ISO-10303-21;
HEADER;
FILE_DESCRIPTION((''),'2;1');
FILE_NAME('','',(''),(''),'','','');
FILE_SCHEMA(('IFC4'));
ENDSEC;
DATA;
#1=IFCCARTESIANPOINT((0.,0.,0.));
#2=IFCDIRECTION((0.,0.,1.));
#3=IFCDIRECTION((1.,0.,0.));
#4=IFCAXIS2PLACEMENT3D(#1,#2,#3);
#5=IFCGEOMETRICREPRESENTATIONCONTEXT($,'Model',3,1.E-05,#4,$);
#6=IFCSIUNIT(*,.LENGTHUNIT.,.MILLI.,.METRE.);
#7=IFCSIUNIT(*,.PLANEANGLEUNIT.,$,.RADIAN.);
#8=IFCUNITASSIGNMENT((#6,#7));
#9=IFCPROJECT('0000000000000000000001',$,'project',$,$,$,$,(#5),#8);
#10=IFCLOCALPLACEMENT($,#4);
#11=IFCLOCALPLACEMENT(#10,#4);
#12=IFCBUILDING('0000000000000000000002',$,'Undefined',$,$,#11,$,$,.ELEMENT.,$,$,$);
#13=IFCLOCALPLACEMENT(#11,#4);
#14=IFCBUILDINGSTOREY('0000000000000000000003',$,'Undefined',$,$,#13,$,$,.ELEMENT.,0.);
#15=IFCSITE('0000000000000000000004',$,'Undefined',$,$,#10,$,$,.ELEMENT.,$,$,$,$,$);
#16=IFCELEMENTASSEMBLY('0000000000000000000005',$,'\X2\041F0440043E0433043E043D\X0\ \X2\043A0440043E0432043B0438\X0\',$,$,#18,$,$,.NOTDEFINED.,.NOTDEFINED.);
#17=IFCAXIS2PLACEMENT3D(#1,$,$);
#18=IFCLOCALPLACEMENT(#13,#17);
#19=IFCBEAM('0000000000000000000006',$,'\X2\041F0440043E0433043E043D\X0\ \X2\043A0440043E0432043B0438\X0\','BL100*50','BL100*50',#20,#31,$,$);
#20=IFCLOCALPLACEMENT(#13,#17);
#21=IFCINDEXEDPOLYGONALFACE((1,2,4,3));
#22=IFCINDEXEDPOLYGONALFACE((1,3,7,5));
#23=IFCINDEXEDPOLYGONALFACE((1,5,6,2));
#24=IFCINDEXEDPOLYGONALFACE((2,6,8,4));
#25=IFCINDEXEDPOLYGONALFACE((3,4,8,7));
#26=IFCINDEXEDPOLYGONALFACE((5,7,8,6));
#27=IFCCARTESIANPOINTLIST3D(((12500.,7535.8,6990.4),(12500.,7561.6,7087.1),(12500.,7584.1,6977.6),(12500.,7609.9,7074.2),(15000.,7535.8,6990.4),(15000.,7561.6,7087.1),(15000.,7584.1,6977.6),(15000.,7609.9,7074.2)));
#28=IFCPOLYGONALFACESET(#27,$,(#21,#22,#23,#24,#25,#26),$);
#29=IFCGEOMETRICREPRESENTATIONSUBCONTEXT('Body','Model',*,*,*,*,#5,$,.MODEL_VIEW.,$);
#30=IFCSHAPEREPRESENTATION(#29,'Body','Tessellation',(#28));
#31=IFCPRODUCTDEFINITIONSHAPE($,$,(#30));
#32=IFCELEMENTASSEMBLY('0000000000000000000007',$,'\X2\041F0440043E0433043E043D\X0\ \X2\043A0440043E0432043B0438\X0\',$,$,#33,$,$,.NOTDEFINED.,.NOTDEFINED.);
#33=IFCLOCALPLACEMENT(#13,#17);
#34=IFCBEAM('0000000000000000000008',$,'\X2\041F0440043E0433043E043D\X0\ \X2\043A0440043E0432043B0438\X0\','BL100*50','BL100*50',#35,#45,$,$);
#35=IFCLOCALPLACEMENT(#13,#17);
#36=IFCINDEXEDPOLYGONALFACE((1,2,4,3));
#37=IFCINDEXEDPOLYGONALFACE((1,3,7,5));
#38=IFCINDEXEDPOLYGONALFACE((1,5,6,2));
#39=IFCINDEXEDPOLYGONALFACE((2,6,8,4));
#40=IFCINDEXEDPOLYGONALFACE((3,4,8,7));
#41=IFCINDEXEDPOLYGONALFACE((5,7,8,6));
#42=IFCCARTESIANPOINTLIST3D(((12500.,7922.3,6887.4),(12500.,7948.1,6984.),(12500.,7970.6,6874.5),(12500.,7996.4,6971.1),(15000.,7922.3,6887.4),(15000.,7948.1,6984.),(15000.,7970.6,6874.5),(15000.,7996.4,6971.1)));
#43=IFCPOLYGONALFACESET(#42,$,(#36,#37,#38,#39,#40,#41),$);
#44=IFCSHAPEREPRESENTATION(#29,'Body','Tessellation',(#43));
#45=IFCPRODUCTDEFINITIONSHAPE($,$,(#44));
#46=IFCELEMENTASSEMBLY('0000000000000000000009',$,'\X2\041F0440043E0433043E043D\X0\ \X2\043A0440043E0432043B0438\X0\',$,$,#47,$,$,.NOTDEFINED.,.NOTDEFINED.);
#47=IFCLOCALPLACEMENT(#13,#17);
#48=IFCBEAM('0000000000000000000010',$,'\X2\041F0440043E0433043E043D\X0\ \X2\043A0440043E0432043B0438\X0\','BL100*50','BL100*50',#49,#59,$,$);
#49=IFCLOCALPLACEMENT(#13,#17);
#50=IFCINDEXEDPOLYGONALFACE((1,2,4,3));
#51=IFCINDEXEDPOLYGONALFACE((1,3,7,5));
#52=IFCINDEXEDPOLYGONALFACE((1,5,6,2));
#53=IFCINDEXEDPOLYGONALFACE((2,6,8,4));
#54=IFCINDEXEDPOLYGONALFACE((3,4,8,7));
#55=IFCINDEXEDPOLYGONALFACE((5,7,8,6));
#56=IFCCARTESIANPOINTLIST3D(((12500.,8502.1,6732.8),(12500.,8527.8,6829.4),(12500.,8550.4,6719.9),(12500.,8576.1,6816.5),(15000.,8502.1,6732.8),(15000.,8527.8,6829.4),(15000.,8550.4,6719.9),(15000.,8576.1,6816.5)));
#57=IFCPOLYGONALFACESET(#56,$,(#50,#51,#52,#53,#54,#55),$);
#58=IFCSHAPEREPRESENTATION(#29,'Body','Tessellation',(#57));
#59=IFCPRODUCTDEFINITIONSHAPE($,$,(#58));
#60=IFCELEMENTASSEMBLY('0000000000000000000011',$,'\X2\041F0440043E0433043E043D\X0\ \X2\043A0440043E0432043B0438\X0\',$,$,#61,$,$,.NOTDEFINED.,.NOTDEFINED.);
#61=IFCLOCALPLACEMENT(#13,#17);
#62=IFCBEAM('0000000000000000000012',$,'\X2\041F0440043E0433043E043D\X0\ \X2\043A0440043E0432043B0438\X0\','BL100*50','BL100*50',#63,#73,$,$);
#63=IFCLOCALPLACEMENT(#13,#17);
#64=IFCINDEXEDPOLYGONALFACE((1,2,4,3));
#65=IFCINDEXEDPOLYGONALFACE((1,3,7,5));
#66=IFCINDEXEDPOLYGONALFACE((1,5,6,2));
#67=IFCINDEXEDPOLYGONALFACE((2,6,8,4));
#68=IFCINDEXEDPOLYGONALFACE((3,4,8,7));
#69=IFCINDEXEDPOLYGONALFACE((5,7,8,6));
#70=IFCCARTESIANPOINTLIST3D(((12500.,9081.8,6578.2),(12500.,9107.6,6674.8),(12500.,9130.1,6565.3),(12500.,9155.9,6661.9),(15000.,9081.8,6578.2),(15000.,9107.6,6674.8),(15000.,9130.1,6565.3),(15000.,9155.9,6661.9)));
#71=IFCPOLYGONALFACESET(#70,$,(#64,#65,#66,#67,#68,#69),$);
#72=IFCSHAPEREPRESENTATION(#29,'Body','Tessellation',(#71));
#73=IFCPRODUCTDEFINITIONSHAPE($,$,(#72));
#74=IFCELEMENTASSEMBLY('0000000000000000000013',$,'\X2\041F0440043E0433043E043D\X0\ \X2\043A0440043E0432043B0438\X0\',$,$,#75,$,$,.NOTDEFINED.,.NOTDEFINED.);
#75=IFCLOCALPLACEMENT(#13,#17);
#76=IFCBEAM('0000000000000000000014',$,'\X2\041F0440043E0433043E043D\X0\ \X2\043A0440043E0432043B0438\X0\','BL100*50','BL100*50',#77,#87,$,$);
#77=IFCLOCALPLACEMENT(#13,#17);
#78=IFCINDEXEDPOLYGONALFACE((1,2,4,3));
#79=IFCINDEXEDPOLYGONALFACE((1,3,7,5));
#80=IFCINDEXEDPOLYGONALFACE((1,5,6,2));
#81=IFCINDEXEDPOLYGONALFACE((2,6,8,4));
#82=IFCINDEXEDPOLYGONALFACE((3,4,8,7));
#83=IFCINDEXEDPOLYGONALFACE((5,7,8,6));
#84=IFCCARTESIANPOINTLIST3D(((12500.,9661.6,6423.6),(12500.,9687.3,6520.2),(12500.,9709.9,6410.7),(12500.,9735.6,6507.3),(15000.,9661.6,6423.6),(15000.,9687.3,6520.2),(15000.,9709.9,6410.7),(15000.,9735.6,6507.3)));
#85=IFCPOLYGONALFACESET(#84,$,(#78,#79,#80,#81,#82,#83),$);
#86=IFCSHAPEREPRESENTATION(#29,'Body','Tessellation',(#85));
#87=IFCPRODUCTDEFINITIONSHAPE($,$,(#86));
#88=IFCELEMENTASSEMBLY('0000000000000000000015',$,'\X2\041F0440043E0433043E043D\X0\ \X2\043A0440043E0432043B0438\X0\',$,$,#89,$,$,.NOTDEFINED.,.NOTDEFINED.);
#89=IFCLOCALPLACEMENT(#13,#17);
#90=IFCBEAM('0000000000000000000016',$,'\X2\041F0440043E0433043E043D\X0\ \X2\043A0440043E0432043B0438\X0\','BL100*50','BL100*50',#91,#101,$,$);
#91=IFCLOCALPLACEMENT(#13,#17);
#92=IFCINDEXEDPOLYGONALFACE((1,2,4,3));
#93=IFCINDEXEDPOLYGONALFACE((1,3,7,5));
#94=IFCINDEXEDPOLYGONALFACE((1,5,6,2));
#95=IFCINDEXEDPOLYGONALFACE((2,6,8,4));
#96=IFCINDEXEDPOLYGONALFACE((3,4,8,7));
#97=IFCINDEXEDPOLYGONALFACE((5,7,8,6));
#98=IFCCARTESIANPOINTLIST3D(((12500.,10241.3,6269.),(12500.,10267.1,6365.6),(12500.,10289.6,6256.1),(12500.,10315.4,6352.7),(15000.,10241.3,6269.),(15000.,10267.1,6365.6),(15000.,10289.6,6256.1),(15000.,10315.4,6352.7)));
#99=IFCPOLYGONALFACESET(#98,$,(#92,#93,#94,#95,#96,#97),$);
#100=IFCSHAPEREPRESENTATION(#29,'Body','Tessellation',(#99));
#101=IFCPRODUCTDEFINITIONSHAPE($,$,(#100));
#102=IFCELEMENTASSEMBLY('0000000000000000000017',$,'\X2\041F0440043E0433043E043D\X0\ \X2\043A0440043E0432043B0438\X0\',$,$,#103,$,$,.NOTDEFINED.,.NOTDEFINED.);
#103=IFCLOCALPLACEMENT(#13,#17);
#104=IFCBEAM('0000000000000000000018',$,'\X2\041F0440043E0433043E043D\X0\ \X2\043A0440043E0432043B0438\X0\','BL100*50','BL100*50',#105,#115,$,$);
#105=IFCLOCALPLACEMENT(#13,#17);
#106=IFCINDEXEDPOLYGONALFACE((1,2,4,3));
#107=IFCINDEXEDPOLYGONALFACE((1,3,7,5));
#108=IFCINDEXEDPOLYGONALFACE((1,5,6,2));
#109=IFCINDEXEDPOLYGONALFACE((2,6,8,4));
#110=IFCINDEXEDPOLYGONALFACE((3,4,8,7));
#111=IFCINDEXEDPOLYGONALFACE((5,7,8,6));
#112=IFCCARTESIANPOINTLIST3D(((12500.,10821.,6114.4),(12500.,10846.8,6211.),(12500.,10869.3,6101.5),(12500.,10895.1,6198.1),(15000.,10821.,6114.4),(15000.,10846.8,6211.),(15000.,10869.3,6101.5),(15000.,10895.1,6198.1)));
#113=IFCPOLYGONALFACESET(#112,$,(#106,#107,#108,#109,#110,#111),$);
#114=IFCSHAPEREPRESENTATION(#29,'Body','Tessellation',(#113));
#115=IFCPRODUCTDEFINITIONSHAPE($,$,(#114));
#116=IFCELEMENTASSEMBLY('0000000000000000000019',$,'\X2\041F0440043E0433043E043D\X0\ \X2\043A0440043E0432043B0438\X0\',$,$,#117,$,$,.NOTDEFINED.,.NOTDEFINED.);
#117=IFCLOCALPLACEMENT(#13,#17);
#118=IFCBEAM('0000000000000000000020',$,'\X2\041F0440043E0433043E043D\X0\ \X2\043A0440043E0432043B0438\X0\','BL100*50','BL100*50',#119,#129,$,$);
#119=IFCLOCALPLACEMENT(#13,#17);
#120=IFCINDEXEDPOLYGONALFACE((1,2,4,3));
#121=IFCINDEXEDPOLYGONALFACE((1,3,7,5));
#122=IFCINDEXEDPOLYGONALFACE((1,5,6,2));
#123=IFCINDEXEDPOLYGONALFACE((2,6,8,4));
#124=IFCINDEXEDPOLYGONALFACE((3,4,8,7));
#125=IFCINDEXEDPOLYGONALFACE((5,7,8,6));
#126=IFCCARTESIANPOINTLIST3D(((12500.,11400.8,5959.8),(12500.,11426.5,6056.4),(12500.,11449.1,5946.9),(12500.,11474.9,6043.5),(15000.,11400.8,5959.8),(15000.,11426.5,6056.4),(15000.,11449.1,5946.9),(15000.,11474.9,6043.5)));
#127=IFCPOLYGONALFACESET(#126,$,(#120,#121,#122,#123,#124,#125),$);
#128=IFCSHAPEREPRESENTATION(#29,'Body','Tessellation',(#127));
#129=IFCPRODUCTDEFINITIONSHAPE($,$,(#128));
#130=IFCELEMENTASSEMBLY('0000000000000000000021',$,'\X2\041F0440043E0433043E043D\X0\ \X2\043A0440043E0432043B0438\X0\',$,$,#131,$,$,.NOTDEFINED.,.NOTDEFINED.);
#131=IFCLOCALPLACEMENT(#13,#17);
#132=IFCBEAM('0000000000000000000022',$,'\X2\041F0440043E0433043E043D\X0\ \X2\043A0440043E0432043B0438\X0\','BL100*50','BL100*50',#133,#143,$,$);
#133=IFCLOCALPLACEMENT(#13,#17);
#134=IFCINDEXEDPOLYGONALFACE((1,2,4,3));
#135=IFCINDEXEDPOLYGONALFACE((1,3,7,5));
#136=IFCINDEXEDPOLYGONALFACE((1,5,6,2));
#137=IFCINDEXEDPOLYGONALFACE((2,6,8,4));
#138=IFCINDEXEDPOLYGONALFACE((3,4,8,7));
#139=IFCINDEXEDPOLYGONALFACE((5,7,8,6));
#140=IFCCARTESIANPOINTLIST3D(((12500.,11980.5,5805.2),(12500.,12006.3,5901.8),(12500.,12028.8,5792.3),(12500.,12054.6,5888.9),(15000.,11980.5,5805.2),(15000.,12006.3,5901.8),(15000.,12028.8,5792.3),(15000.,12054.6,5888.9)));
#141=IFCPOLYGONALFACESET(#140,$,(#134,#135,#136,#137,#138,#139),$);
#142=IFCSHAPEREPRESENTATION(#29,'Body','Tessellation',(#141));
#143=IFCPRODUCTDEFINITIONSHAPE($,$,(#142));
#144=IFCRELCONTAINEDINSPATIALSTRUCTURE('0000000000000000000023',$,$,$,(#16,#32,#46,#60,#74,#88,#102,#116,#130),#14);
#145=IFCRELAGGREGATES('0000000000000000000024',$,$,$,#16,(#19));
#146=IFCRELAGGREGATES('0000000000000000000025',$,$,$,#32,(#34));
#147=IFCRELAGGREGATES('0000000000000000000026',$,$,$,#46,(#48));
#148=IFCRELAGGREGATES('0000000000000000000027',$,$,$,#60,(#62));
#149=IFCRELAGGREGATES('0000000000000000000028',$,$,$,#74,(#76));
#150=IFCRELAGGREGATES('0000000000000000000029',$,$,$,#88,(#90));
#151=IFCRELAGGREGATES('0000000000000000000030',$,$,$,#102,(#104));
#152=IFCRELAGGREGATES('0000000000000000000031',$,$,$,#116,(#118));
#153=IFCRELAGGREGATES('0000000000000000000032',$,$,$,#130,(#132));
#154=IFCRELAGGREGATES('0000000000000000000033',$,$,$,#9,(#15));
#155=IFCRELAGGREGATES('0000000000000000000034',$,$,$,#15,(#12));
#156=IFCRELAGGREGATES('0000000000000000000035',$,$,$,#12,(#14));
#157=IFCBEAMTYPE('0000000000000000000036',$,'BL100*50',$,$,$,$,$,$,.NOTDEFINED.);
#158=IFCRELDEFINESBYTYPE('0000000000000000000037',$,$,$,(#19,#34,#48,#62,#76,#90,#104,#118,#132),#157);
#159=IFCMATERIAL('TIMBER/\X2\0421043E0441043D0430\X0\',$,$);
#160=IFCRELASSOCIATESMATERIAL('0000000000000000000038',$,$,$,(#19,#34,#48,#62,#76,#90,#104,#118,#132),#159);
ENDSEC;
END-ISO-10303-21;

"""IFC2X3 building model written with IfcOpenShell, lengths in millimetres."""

from ifc_helpers import new_model, si_unit, frame, origin_with_axes, origin_2d_with_axis, place, context, subcontext, project, spatial, rectangle, extrude, material, type_object, element, aggregate, save


model = new_model("IFC2X3")

# Units and contexts
model_context = context("Model", 3, precision=1e-05, world=origin_with_axes())
body_context = subcontext(model_context, "Body", "Model", "MODEL_VIEW")
ifc_project = project(units=[si_unit("LENGTHUNIT", "METRE", prefix="MILLI"), si_unit("PLANEANGLEUNIT", "RADIAN")], contexts=[model_context])

# Site, building, storey
site_placement = place(None, origin_with_axes())
site = spatial("IfcSite", under=ifc_project, at=site_placement, Name="Undefined", CompositionType="ELEMENT")
building_placement = place(site_placement, origin_with_axes())
building = spatial("IfcBuilding", under=site, at=building_placement, Name="Undefined", CompositionType="ELEMENT")
storey_placement = place(building_placement, origin_with_axes())
storey = spatial("IfcBuildingStorey", under=building, at=storey_placement, Name="Undefined", CompositionType="ELEMENT", Elevation=0.0)

# Element assemblies, beams
assembly_1_placement = place(storey_placement, origin_with_axes())
assembly_1 = element("IfcElementAssembly", 1, at=assembly_1_placement, inside=storey, Name="Прогон кровли", AssemblyPlace="NOTDEFINED", PredefinedType="NOTDEFINED")
ifc_material_1 = material(Name="TIMBER/Сосна")
beam_type_1 = type_object("IfcBeamType", Name="BL100*50", PredefinedType="NOTDEFINED")
beam_1_placement = place(assembly_1_placement, frame((12500.0, 7572.9, 7032.3), z_axis=(0.0, -0.257663, -0.966235), x_axis=(1.0, 0.0, 0.0)))
beam_1 = element("IfcBeam", 2, at=beam_1_placement, type_object=beam_type_1, material=ifc_material_1, Name="Прогон кровли", Description="BL100*50", ObjectType="BL100*50", context=body_context, shape_type="SweptSolid", body=[
    extrude(rectangle(XDim=50.0, YDim=100.0, at=origin_2d_with_axis()), frame((2500.0, 0.0, 0.0), z_axis=(-1.0, 0.0, 0.0), x_axis=(0.0, -1.0, 0.0)), (0.0, 0.0, 1.0), 2500.0),
])
aggregate(assembly_1, [beam_1])
assembly_2_placement = place(storey_placement, origin_with_axes())
assembly_2 = element("IfcElementAssembly", 3, at=assembly_2_placement, inside=storey, Name="Прогон кровли", AssemblyPlace="NOTDEFINED", PredefinedType="NOTDEFINED")
beam_2_placement = place(assembly_2_placement, frame((12500.0, 7959.4, 6929.2), z_axis=(0.0, -0.257663, -0.966235), x_axis=(1.0, 0.0, 0.0)))
beam_2 = element("IfcBeam", 4, at=beam_2_placement, type_object=beam_type_1, material=ifc_material_1, Name="Прогон кровли", Description="BL100*50", ObjectType="BL100*50", context=body_context, shape_type="SweptSolid", body=[
    extrude(rectangle(XDim=50.0, YDim=100.0, at=origin_2d_with_axis()), frame((2500.0, 0.0, 0.0), z_axis=(-1.0, 0.0, 0.0), x_axis=(0.0, -1.0, 0.0)), (0.0, 0.0, 1.0), 2500.0),
])
aggregate(assembly_2, [beam_2])
assembly_3_placement = place(storey_placement, origin_with_axes())
assembly_3 = element("IfcElementAssembly", 5, at=assembly_3_placement, inside=storey, Name="Прогон кровли", AssemblyPlace="NOTDEFINED", PredefinedType="NOTDEFINED")
beam_3_placement = place(assembly_3_placement, frame((12500.0, 8539.1, 6774.7), z_axis=(0.0, -0.257663, -0.966235), x_axis=(1.0, 0.0, 0.0)))
beam_3 = element("IfcBeam", 6, at=beam_3_placement, type_object=beam_type_1, material=ifc_material_1, Name="Прогон кровли", Description="BL100*50", ObjectType="BL100*50", context=body_context, shape_type="SweptSolid", body=[
    extrude(rectangle(XDim=50.0, YDim=100.0, at=origin_2d_with_axis()), frame((2500.0, 0.0, 0.0), z_axis=(-1.0, 0.0, 0.0), x_axis=(0.0, -1.0, 0.0)), (0.0, 0.0, 1.0), 2500.0),
])
aggregate(assembly_3, [beam_3])
assembly_4_placement = place(storey_placement, origin_with_axes())
assembly_4 = element("IfcElementAssembly", 7, at=assembly_4_placement, inside=storey, Name="Прогон кровли", AssemblyPlace="NOTDEFINED", PredefinedType="NOTDEFINED")
beam_4_placement = place(assembly_4_placement, frame((12500.0, 9118.9, 6620.1), z_axis=(0.0, -0.257663, -0.966235), x_axis=(1.0, 0.0, 0.0)))
beam_4 = element("IfcBeam", 8, at=beam_4_placement, type_object=beam_type_1, material=ifc_material_1, Name="Прогон кровли", Description="BL100*50", ObjectType="BL100*50", context=body_context, shape_type="SweptSolid", body=[
    extrude(rectangle(XDim=50.0, YDim=100.0, at=origin_2d_with_axis()), frame((2500.0, 0.0, 0.0), z_axis=(-1.0, 0.0, 0.0), x_axis=(0.0, -1.0, 0.0)), (0.0, 0.0, 1.0), 2500.0),
])
aggregate(assembly_4, [beam_4])
assembly_5_placement = place(storey_placement, origin_with_axes())
assembly_5 = element("IfcElementAssembly", 9, at=assembly_5_placement, inside=storey, Name="Прогон кровли", AssemblyPlace="NOTDEFINED", PredefinedType="NOTDEFINED")
beam_5_placement = place(assembly_5_placement, frame((12500.0, 9698.6, 6465.5), z_axis=(0.0, -0.257663, -0.966235), x_axis=(1.0, 0.0, 0.0)))
beam_5 = element("IfcBeam", 10, at=beam_5_placement, type_object=beam_type_1, material=ifc_material_1, Name="Прогон кровли", Description="BL100*50", ObjectType="BL100*50", context=body_context, shape_type="SweptSolid", body=[
    extrude(rectangle(XDim=50.0, YDim=100.0, at=origin_2d_with_axis()), frame((2500.0, 0.0, 0.0), z_axis=(-1.0, 0.0, 0.0), x_axis=(0.0, -1.0, 0.0)), (0.0, 0.0, 1.0), 2500.0),
])
aggregate(assembly_5, [beam_5])
assembly_6_placement = place(storey_placement, origin_with_axes())
assembly_6 = element("IfcElementAssembly", 11, at=assembly_6_placement, inside=storey, Name="Прогон кровли", AssemblyPlace="NOTDEFINED", PredefinedType="NOTDEFINED")
beam_6_placement = place(assembly_6_placement, frame((12500.0, 10278.3, 6310.9), z_axis=(0.0, -0.257663, -0.966235), x_axis=(1.0, 0.0, 0.0)))
beam_6 = element("IfcBeam", 12, at=beam_6_placement, type_object=beam_type_1, material=ifc_material_1, Name="Прогон кровли", Description="BL100*50", ObjectType="BL100*50", context=body_context, shape_type="SweptSolid", body=[
    extrude(rectangle(XDim=50.0, YDim=100.0, at=origin_2d_with_axis()), frame((2500.0, 0.0, 0.0), z_axis=(-1.0, 0.0, 0.0), x_axis=(0.0, -1.0, 0.0)), (0.0, 0.0, 1.0), 2500.0),
])
aggregate(assembly_6, [beam_6])
assembly_7_placement = place(storey_placement, origin_with_axes())
assembly_7 = element("IfcElementAssembly", 13, at=assembly_7_placement, inside=storey, Name="Прогон кровли", AssemblyPlace="NOTDEFINED", PredefinedType="NOTDEFINED")
beam_7_placement = place(assembly_7_placement, frame((12500.0, 10858.1, 6156.3), z_axis=(0.0, -0.257663, -0.966235), x_axis=(1.0, 0.0, 0.0)))
beam_7 = element("IfcBeam", 14, at=beam_7_placement, type_object=beam_type_1, material=ifc_material_1, Name="Прогон кровли", Description="BL100*50", ObjectType="BL100*50", context=body_context, shape_type="SweptSolid", body=[
    extrude(rectangle(XDim=50.0, YDim=100.0, at=origin_2d_with_axis()), frame((2500.0, 0.0, 0.0), z_axis=(-1.0, 0.0, 0.0), x_axis=(0.0, -1.0, 0.0)), (0.0, 0.0, 1.0), 2500.0),
])
aggregate(assembly_7, [beam_7])
assembly_8_placement = place(storey_placement, origin_with_axes())
assembly_8 = element("IfcElementAssembly", 15, at=assembly_8_placement, inside=storey, Name="Прогон кровли", AssemblyPlace="NOTDEFINED", PredefinedType="NOTDEFINED")
beam_8_placement = place(assembly_8_placement, frame((12500.0, 11437.8, 6001.7), z_axis=(0.0, -0.257663, -0.966235), x_axis=(1.0, 0.0, 0.0)))
beam_8 = element("IfcBeam", 16, at=beam_8_placement, type_object=beam_type_1, material=ifc_material_1, Name="Прогон кровли", Description="BL100*50", ObjectType="BL100*50", context=body_context, shape_type="SweptSolid", body=[
    extrude(rectangle(XDim=50.0, YDim=100.0, at=origin_2d_with_axis()), frame((2500.0, 0.0, 0.0), z_axis=(-1.0, 0.0, 0.0), x_axis=(0.0, -1.0, 0.0)), (0.0, 0.0, 1.0), 2500.0),
])
aggregate(assembly_8, [beam_8])
assembly_9_placement = place(storey_placement, origin_with_axes())
assembly_9 = element("IfcElementAssembly", 17, at=assembly_9_placement, inside=storey, Name="Прогон кровли", AssemblyPlace="NOTDEFINED", PredefinedType="NOTDEFINED")
beam_9_placement = place(assembly_9_placement, frame((12500.0, 12017.6, 5847.1), z_axis=(0.0, -0.257663, -0.966235), x_axis=(1.0, 0.0, 0.0)))
beam_9 = element("IfcBeam", 18, at=beam_9_placement, type_object=beam_type_1, material=ifc_material_1, Name="Прогон кровли", Description="BL100*50", ObjectType="BL100*50", context=body_context, shape_type="SweptSolid", body=[
    extrude(rectangle(XDim=50.0, YDim=100.0, at=origin_2d_with_axis()), frame((2500.0, 0.0, 0.0), z_axis=(-1.0, 0.0, 0.0), x_axis=(0.0, -1.0, 0.0)), (0.0, 0.0, 1.0), 2500.0),
])
aggregate(assembly_9, [beam_9])

save(model, "model.ifc")
